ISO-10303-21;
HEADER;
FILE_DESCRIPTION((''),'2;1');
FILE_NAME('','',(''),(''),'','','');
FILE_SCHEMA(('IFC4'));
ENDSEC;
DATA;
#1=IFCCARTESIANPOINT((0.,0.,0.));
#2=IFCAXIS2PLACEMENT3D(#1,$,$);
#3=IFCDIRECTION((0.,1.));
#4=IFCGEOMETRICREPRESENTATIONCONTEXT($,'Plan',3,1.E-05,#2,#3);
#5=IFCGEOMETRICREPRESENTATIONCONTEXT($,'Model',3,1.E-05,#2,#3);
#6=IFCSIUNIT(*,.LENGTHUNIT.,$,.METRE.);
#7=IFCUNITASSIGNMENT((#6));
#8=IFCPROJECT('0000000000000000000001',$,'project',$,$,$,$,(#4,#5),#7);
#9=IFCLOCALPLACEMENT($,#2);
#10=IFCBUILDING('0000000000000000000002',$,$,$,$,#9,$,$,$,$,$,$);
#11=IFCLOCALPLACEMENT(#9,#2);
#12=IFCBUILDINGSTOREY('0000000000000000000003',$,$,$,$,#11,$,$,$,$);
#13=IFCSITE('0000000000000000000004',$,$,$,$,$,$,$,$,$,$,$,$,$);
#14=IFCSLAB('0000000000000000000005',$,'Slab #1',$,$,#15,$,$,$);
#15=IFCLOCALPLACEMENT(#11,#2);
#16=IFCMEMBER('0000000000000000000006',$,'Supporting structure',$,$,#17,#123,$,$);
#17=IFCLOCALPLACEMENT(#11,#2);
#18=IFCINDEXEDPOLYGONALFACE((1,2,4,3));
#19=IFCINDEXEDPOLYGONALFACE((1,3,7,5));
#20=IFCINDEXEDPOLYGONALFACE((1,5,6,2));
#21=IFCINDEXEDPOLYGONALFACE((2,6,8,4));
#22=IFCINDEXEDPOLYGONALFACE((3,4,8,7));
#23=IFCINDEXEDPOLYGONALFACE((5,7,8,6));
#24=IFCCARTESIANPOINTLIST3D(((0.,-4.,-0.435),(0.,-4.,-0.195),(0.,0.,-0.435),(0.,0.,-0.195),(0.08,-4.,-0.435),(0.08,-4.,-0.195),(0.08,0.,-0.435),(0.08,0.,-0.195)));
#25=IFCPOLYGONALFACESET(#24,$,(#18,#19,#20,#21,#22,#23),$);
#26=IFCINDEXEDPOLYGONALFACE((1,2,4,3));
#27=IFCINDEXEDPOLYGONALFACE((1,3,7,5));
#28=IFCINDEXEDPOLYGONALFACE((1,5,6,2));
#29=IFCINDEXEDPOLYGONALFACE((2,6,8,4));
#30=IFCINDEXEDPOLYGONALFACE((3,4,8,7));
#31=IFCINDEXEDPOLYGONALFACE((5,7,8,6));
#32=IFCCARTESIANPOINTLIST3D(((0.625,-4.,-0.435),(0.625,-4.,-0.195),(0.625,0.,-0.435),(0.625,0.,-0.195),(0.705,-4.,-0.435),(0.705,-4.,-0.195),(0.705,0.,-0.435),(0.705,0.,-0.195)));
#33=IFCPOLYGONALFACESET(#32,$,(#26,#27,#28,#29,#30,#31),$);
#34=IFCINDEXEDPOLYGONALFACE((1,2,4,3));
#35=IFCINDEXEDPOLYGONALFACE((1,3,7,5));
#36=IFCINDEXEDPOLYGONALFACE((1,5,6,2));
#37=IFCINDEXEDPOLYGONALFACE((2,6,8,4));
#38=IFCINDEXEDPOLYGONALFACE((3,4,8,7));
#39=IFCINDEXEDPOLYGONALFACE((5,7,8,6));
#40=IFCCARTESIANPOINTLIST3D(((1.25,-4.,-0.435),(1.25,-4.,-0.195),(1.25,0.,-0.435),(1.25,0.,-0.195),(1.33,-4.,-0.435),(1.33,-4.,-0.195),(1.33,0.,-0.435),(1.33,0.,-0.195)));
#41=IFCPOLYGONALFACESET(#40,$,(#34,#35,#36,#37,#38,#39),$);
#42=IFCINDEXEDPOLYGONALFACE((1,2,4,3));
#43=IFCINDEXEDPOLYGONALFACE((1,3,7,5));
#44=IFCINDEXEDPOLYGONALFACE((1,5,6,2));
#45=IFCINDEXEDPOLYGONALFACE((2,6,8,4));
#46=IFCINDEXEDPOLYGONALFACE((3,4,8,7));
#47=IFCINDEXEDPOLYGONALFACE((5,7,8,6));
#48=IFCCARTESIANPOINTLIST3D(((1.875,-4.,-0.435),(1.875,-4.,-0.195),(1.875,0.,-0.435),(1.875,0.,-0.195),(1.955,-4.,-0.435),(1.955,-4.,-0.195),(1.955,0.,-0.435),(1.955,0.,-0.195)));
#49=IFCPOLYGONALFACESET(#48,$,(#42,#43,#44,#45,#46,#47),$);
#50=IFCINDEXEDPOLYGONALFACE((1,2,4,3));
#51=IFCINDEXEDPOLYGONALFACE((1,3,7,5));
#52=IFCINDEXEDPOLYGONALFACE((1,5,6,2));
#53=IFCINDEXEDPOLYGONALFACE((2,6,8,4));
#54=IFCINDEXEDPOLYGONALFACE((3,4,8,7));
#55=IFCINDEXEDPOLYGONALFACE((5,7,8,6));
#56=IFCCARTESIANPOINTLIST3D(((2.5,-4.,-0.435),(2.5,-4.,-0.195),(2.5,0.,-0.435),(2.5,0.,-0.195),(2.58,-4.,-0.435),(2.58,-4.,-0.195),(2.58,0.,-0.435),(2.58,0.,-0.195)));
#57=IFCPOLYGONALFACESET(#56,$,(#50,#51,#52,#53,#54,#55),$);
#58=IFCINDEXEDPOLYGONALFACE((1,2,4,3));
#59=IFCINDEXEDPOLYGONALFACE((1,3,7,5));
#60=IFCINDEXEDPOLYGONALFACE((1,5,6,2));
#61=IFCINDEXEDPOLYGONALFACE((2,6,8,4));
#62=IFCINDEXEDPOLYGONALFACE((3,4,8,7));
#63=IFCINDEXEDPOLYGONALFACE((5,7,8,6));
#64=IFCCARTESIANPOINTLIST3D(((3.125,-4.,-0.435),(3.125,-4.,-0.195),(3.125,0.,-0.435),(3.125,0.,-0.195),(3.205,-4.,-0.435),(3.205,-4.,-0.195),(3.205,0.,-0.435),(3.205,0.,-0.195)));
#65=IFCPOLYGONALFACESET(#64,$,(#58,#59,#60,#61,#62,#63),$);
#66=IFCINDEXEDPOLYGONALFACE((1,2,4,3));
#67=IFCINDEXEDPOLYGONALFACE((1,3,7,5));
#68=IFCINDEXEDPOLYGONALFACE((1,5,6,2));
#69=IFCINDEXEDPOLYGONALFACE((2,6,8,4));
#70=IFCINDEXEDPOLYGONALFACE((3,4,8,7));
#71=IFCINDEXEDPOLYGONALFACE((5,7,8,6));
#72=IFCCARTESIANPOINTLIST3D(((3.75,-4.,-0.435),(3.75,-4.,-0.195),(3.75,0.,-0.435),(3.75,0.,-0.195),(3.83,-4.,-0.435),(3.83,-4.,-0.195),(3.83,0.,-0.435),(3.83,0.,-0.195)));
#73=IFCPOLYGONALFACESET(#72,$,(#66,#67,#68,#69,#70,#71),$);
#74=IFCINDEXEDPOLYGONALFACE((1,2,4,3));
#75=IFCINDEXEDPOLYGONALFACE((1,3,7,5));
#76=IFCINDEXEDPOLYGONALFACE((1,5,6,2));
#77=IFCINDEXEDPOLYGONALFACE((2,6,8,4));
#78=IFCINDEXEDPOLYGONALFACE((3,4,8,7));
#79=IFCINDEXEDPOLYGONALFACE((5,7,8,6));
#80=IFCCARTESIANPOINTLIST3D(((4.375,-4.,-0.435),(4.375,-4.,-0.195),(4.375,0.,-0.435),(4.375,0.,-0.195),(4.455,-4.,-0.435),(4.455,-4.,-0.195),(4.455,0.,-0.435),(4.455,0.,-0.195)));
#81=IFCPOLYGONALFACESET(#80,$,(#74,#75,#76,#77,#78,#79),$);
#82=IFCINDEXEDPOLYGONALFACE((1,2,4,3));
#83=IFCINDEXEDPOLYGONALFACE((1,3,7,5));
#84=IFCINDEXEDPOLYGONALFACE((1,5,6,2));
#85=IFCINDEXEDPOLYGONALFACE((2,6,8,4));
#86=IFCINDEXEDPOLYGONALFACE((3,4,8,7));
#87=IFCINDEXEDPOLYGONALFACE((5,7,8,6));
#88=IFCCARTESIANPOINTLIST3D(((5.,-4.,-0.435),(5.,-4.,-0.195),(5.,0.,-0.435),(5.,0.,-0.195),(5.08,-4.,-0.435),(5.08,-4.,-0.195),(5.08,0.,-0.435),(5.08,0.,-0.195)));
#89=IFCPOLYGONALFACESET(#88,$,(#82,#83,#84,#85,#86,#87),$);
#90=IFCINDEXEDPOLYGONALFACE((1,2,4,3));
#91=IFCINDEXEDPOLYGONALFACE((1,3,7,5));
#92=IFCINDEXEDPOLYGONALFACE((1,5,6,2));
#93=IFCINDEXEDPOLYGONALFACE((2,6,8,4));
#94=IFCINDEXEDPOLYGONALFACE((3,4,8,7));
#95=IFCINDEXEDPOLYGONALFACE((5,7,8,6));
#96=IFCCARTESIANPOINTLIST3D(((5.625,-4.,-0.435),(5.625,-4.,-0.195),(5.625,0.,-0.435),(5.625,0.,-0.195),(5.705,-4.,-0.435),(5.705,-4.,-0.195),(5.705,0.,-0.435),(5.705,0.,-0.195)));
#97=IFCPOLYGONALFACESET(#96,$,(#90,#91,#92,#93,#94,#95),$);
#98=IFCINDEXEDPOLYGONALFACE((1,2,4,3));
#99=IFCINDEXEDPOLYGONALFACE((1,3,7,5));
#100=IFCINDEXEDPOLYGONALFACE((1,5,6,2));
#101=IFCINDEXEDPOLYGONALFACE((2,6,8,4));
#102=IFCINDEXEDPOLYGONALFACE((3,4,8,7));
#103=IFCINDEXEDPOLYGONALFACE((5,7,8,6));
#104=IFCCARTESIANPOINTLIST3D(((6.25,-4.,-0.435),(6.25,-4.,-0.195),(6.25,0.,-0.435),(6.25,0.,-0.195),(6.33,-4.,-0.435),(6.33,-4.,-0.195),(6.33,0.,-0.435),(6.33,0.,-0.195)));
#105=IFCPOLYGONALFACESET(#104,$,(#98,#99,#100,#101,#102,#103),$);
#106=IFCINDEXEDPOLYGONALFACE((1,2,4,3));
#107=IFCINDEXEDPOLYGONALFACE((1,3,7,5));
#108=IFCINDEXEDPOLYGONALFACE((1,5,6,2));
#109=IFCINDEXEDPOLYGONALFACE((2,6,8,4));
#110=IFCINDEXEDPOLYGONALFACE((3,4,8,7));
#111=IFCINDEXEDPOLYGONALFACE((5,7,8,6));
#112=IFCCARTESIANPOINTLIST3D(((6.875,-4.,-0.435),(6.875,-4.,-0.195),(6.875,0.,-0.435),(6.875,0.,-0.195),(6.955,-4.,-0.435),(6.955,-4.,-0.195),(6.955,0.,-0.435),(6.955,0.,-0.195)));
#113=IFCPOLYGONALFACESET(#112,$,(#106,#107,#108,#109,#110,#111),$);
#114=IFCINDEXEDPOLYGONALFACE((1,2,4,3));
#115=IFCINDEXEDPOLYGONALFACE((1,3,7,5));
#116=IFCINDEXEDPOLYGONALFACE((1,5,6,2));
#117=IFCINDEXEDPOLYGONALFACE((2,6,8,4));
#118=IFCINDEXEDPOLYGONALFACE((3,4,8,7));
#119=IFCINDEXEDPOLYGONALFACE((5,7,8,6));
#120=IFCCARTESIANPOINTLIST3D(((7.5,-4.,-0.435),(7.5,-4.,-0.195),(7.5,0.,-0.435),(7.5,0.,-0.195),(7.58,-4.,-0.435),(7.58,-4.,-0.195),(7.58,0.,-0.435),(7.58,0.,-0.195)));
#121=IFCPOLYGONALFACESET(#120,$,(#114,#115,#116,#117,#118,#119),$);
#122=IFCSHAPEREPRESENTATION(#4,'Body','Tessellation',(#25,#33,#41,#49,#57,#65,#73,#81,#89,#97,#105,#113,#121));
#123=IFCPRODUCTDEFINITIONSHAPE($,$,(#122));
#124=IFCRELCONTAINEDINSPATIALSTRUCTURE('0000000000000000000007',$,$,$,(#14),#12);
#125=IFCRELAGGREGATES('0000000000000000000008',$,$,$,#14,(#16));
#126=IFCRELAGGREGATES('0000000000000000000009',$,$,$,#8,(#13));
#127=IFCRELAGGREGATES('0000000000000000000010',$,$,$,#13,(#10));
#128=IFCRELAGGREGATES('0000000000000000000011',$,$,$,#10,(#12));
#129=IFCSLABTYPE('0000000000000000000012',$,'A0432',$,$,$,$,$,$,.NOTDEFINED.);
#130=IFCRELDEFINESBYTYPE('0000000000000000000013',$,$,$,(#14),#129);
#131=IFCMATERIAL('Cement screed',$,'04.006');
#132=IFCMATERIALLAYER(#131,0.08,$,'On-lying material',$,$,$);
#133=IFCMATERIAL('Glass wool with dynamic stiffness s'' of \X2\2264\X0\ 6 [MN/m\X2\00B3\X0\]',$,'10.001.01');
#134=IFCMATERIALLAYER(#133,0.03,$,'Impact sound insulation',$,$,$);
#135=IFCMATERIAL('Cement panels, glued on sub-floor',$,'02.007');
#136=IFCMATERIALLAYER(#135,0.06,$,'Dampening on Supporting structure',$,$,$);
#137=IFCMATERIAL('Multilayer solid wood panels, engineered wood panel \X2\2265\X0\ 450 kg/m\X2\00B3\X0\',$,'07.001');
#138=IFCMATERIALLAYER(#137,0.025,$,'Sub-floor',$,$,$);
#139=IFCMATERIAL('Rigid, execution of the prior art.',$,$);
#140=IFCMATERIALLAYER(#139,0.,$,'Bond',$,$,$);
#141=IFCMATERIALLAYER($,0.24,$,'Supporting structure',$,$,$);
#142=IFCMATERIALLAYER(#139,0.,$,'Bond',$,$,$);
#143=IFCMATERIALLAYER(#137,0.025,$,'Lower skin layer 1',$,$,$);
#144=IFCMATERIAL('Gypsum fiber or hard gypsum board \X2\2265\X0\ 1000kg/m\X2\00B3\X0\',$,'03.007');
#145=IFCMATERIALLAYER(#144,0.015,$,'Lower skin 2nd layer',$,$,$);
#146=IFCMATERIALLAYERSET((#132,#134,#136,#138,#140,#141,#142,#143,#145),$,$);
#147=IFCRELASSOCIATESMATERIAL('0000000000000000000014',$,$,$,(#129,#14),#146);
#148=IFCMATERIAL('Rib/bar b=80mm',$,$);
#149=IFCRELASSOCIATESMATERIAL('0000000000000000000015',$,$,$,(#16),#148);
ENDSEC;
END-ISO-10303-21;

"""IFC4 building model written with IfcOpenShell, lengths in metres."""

from ifc_helpers import new_model, si_unit, direction, frame, frame_2d, origin, place, context, project, spatial, rectangle, extrude, material, layer, layer_set, type_object, element, aggregate, save


model = new_model("IFC4")

# Units and contexts
plan_context = context("Plan", 3, precision=1e-05, world=origin(), true_north=direction((0.0, 1.0)))
model_context = context("Model", 3, precision=1e-05, world=origin(), true_north=direction((0.0, 1.0)))
ifc_project = project(units=[si_unit("LENGTHUNIT", "METRE")], contexts=[plan_context, model_context])

# Site, building, storey
site = spatial("IfcSite", under=ifc_project)
building_placement = place(None, origin())
building = spatial("IfcBuilding", under=site, at=building_placement)
storey_placement = place(building_placement, origin())
storey = spatial("IfcBuildingStorey", under=building, at=storey_placement)

# Slab, member
ifc_material_1 = material(Name="Cement screed", Category="04.006")
ifc_layer_1 = layer(ifc_material_1, 0.08, Name="On-lying material")
ifc_material_2 = material(Name="Glass wool with dynamic stiffness s' of ≤ 6 [MN/m³]", Category="10.001.01")
ifc_layer_2 = layer(ifc_material_2, 0.03, Name="Impact sound insulation")
ifc_material_3 = material(Name="Cement panels, glued on sub-floor", Category="02.007")
ifc_layer_3 = layer(ifc_material_3, 0.06, Name="Dampening on Supporting structure")
ifc_material_4 = material(Name="Multilayer solid wood panels, engineered wood panel ≥ 450 kg/m³", Category="07.001")
ifc_layer_4 = layer(ifc_material_4, 0.025, Name="Sub-floor")
ifc_material_5 = material(Name="Rigid, execution of the prior art.")
ifc_layer_5 = layer(ifc_material_5, 0.0, Name="Bond")
ifc_layer_6 = layer(None, 0.24, Name="Supporting structure")
ifc_layer_7 = layer(ifc_material_5, 0.0, Name="Bond")
ifc_layer_8 = layer(ifc_material_4, 0.025, Name="Lower skin layer 1")
ifc_material_6 = material(Name="Gypsum fiber or hard gypsum board ≥ 1000kg/m³", Category="03.007")
ifc_layer_9 = layer(ifc_material_6, 0.015, Name="Lower skin 2nd layer")
ifc_layer_set = layer_set([ifc_layer_1, ifc_layer_2, ifc_layer_3, ifc_layer_4, ifc_layer_5, ifc_layer_6, ifc_layer_7, ifc_layer_8, ifc_layer_9])
slab_type = type_object("IfcSlabType", Name="A0432", PredefinedType="NOTDEFINED", material=ifc_layer_set)
slab_placement = place(None, frame((0.0, 0.0, 0.0), z_axis=(0.0, 0.0, -1.0), x_axis=(1.0, 0.0, 0.0)))
slab = element("IfcSlab", 1, at=slab_placement, inside=storey, type_object=slab_type, material=ifc_layer_set, Name="Slab #1")
ifc_material_7 = material(Name="Rib/bar b=80mm")
member_1_placement = place(slab_placement, origin())
member_1 = element("IfcMember", 2, at=member_1_placement, material=ifc_material_7, Name="Supporting structure", context=plan_context, shape_type="SweptSolid", body=[
    extrude(rectangle(XDim=0.08, YDim=0.24, at=frame_2d((0.04, 0.12), x_axis=(1.0, 0.0))), frame((0.0, 4.0, 0.195), z_axis=(0.0, -1.0, 0.0), x_axis=(1.0, 0.0, 0.0)), (0.0, 0.0, 1.0), 4.0),
    extrude(rectangle(XDim=0.08, YDim=0.24, at=frame_2d((0.04, 0.12), x_axis=(1.0, 0.0))), frame((0.625, 4.0, 0.195), z_axis=(0.0, -1.0, 0.0), x_axis=(1.0, 0.0, 0.0)), (0.0, 0.0, 1.0), 4.0),
    extrude(rectangle(XDim=0.08, YDim=0.24, at=frame_2d((0.04, 0.12), x_axis=(1.0, 0.0))), frame((1.25, 4.0, 0.195), z_axis=(0.0, -1.0, 0.0), x_axis=(1.0, 0.0, 0.0)), (0.0, 0.0, 1.0), 4.0),
    extrude(rectangle(XDim=0.08, YDim=0.24, at=frame_2d((0.04, 0.12), x_axis=(1.0, 0.0))), frame((1.875, 4.0, 0.195), z_axis=(0.0, -1.0, 0.0), x_axis=(1.0, 0.0, 0.0)), (0.0, 0.0, 1.0), 4.0),
    extrude(rectangle(XDim=0.08, YDim=0.24, at=frame_2d((0.04, 0.12), x_axis=(1.0, 0.0))), frame((2.5, 4.0, 0.195), z_axis=(0.0, -1.0, 0.0), x_axis=(1.0, 0.0, 0.0)), (0.0, 0.0, 1.0), 4.0),
    extrude(rectangle(XDim=0.08, YDim=0.24, at=frame_2d((0.04, 0.12), x_axis=(1.0, 0.0))), frame((3.125, 4.0, 0.195), z_axis=(0.0, -1.0, 0.0), x_axis=(1.0, 0.0, 0.0)), (0.0, 0.0, 1.0), 4.0),
    extrude(rectangle(XDim=0.08, YDim=0.24, at=frame_2d((0.04, 0.12), x_axis=(1.0, 0.0))), frame((3.75, 4.0, 0.195), z_axis=(0.0, -1.0, 0.0), x_axis=(1.0, 0.0, 0.0)), (0.0, 0.0, 1.0), 4.0),
    extrude(rectangle(XDim=0.08, YDim=0.24, at=frame_2d((0.04, 0.12), x_axis=(1.0, 0.0))), frame((4.375, 4.0, 0.195), z_axis=(0.0, -1.0, 0.0), x_axis=(1.0, 0.0, 0.0)), (0.0, 0.0, 1.0), 4.0),
    extrude(rectangle(XDim=0.08, YDim=0.24, at=frame_2d((0.04, 0.12), x_axis=(1.0, 0.0))), frame((5.0, 4.0, 0.195), z_axis=(0.0, -1.0, 0.0), x_axis=(1.0, 0.0, 0.0)), (0.0, 0.0, 1.0), 4.0),
    extrude(rectangle(XDim=0.08, YDim=0.24, at=frame_2d((0.04, 0.12), x_axis=(1.0, 0.0))), frame((5.625, 4.0, 0.195), z_axis=(0.0, -1.0, 0.0), x_axis=(1.0, 0.0, 0.0)), (0.0, 0.0, 1.0), 4.0),
    extrude(rectangle(XDim=0.08, YDim=0.24, at=frame_2d((0.04, 0.12), x_axis=(1.0, 0.0))), frame((6.25, 4.0, 0.195), z_axis=(0.0, -1.0, 0.0), x_axis=(1.0, 0.0, 0.0)), (0.0, 0.0, 1.0), 4.0),
    extrude(rectangle(XDim=0.08, YDim=0.24, at=frame_2d((0.04, 0.12), x_axis=(1.0, 0.0))), frame((6.875, 4.0, 0.195), z_axis=(0.0, -1.0, 0.0), x_axis=(1.0, 0.0, 0.0)), (0.0, 0.0, 1.0), 4.0),
    extrude(rectangle(XDim=0.08, YDim=0.24, at=frame_2d((0.04, 0.12), x_axis=(1.0, 0.0))), frame((7.5, 4.0, 0.195), z_axis=(0.0, -1.0, 0.0), x_axis=(1.0, 0.0, 0.0)), (0.0, 0.0, 1.0), 4.0),
])
aggregate(slab, [member_1])

save(model, "model.ifc")
